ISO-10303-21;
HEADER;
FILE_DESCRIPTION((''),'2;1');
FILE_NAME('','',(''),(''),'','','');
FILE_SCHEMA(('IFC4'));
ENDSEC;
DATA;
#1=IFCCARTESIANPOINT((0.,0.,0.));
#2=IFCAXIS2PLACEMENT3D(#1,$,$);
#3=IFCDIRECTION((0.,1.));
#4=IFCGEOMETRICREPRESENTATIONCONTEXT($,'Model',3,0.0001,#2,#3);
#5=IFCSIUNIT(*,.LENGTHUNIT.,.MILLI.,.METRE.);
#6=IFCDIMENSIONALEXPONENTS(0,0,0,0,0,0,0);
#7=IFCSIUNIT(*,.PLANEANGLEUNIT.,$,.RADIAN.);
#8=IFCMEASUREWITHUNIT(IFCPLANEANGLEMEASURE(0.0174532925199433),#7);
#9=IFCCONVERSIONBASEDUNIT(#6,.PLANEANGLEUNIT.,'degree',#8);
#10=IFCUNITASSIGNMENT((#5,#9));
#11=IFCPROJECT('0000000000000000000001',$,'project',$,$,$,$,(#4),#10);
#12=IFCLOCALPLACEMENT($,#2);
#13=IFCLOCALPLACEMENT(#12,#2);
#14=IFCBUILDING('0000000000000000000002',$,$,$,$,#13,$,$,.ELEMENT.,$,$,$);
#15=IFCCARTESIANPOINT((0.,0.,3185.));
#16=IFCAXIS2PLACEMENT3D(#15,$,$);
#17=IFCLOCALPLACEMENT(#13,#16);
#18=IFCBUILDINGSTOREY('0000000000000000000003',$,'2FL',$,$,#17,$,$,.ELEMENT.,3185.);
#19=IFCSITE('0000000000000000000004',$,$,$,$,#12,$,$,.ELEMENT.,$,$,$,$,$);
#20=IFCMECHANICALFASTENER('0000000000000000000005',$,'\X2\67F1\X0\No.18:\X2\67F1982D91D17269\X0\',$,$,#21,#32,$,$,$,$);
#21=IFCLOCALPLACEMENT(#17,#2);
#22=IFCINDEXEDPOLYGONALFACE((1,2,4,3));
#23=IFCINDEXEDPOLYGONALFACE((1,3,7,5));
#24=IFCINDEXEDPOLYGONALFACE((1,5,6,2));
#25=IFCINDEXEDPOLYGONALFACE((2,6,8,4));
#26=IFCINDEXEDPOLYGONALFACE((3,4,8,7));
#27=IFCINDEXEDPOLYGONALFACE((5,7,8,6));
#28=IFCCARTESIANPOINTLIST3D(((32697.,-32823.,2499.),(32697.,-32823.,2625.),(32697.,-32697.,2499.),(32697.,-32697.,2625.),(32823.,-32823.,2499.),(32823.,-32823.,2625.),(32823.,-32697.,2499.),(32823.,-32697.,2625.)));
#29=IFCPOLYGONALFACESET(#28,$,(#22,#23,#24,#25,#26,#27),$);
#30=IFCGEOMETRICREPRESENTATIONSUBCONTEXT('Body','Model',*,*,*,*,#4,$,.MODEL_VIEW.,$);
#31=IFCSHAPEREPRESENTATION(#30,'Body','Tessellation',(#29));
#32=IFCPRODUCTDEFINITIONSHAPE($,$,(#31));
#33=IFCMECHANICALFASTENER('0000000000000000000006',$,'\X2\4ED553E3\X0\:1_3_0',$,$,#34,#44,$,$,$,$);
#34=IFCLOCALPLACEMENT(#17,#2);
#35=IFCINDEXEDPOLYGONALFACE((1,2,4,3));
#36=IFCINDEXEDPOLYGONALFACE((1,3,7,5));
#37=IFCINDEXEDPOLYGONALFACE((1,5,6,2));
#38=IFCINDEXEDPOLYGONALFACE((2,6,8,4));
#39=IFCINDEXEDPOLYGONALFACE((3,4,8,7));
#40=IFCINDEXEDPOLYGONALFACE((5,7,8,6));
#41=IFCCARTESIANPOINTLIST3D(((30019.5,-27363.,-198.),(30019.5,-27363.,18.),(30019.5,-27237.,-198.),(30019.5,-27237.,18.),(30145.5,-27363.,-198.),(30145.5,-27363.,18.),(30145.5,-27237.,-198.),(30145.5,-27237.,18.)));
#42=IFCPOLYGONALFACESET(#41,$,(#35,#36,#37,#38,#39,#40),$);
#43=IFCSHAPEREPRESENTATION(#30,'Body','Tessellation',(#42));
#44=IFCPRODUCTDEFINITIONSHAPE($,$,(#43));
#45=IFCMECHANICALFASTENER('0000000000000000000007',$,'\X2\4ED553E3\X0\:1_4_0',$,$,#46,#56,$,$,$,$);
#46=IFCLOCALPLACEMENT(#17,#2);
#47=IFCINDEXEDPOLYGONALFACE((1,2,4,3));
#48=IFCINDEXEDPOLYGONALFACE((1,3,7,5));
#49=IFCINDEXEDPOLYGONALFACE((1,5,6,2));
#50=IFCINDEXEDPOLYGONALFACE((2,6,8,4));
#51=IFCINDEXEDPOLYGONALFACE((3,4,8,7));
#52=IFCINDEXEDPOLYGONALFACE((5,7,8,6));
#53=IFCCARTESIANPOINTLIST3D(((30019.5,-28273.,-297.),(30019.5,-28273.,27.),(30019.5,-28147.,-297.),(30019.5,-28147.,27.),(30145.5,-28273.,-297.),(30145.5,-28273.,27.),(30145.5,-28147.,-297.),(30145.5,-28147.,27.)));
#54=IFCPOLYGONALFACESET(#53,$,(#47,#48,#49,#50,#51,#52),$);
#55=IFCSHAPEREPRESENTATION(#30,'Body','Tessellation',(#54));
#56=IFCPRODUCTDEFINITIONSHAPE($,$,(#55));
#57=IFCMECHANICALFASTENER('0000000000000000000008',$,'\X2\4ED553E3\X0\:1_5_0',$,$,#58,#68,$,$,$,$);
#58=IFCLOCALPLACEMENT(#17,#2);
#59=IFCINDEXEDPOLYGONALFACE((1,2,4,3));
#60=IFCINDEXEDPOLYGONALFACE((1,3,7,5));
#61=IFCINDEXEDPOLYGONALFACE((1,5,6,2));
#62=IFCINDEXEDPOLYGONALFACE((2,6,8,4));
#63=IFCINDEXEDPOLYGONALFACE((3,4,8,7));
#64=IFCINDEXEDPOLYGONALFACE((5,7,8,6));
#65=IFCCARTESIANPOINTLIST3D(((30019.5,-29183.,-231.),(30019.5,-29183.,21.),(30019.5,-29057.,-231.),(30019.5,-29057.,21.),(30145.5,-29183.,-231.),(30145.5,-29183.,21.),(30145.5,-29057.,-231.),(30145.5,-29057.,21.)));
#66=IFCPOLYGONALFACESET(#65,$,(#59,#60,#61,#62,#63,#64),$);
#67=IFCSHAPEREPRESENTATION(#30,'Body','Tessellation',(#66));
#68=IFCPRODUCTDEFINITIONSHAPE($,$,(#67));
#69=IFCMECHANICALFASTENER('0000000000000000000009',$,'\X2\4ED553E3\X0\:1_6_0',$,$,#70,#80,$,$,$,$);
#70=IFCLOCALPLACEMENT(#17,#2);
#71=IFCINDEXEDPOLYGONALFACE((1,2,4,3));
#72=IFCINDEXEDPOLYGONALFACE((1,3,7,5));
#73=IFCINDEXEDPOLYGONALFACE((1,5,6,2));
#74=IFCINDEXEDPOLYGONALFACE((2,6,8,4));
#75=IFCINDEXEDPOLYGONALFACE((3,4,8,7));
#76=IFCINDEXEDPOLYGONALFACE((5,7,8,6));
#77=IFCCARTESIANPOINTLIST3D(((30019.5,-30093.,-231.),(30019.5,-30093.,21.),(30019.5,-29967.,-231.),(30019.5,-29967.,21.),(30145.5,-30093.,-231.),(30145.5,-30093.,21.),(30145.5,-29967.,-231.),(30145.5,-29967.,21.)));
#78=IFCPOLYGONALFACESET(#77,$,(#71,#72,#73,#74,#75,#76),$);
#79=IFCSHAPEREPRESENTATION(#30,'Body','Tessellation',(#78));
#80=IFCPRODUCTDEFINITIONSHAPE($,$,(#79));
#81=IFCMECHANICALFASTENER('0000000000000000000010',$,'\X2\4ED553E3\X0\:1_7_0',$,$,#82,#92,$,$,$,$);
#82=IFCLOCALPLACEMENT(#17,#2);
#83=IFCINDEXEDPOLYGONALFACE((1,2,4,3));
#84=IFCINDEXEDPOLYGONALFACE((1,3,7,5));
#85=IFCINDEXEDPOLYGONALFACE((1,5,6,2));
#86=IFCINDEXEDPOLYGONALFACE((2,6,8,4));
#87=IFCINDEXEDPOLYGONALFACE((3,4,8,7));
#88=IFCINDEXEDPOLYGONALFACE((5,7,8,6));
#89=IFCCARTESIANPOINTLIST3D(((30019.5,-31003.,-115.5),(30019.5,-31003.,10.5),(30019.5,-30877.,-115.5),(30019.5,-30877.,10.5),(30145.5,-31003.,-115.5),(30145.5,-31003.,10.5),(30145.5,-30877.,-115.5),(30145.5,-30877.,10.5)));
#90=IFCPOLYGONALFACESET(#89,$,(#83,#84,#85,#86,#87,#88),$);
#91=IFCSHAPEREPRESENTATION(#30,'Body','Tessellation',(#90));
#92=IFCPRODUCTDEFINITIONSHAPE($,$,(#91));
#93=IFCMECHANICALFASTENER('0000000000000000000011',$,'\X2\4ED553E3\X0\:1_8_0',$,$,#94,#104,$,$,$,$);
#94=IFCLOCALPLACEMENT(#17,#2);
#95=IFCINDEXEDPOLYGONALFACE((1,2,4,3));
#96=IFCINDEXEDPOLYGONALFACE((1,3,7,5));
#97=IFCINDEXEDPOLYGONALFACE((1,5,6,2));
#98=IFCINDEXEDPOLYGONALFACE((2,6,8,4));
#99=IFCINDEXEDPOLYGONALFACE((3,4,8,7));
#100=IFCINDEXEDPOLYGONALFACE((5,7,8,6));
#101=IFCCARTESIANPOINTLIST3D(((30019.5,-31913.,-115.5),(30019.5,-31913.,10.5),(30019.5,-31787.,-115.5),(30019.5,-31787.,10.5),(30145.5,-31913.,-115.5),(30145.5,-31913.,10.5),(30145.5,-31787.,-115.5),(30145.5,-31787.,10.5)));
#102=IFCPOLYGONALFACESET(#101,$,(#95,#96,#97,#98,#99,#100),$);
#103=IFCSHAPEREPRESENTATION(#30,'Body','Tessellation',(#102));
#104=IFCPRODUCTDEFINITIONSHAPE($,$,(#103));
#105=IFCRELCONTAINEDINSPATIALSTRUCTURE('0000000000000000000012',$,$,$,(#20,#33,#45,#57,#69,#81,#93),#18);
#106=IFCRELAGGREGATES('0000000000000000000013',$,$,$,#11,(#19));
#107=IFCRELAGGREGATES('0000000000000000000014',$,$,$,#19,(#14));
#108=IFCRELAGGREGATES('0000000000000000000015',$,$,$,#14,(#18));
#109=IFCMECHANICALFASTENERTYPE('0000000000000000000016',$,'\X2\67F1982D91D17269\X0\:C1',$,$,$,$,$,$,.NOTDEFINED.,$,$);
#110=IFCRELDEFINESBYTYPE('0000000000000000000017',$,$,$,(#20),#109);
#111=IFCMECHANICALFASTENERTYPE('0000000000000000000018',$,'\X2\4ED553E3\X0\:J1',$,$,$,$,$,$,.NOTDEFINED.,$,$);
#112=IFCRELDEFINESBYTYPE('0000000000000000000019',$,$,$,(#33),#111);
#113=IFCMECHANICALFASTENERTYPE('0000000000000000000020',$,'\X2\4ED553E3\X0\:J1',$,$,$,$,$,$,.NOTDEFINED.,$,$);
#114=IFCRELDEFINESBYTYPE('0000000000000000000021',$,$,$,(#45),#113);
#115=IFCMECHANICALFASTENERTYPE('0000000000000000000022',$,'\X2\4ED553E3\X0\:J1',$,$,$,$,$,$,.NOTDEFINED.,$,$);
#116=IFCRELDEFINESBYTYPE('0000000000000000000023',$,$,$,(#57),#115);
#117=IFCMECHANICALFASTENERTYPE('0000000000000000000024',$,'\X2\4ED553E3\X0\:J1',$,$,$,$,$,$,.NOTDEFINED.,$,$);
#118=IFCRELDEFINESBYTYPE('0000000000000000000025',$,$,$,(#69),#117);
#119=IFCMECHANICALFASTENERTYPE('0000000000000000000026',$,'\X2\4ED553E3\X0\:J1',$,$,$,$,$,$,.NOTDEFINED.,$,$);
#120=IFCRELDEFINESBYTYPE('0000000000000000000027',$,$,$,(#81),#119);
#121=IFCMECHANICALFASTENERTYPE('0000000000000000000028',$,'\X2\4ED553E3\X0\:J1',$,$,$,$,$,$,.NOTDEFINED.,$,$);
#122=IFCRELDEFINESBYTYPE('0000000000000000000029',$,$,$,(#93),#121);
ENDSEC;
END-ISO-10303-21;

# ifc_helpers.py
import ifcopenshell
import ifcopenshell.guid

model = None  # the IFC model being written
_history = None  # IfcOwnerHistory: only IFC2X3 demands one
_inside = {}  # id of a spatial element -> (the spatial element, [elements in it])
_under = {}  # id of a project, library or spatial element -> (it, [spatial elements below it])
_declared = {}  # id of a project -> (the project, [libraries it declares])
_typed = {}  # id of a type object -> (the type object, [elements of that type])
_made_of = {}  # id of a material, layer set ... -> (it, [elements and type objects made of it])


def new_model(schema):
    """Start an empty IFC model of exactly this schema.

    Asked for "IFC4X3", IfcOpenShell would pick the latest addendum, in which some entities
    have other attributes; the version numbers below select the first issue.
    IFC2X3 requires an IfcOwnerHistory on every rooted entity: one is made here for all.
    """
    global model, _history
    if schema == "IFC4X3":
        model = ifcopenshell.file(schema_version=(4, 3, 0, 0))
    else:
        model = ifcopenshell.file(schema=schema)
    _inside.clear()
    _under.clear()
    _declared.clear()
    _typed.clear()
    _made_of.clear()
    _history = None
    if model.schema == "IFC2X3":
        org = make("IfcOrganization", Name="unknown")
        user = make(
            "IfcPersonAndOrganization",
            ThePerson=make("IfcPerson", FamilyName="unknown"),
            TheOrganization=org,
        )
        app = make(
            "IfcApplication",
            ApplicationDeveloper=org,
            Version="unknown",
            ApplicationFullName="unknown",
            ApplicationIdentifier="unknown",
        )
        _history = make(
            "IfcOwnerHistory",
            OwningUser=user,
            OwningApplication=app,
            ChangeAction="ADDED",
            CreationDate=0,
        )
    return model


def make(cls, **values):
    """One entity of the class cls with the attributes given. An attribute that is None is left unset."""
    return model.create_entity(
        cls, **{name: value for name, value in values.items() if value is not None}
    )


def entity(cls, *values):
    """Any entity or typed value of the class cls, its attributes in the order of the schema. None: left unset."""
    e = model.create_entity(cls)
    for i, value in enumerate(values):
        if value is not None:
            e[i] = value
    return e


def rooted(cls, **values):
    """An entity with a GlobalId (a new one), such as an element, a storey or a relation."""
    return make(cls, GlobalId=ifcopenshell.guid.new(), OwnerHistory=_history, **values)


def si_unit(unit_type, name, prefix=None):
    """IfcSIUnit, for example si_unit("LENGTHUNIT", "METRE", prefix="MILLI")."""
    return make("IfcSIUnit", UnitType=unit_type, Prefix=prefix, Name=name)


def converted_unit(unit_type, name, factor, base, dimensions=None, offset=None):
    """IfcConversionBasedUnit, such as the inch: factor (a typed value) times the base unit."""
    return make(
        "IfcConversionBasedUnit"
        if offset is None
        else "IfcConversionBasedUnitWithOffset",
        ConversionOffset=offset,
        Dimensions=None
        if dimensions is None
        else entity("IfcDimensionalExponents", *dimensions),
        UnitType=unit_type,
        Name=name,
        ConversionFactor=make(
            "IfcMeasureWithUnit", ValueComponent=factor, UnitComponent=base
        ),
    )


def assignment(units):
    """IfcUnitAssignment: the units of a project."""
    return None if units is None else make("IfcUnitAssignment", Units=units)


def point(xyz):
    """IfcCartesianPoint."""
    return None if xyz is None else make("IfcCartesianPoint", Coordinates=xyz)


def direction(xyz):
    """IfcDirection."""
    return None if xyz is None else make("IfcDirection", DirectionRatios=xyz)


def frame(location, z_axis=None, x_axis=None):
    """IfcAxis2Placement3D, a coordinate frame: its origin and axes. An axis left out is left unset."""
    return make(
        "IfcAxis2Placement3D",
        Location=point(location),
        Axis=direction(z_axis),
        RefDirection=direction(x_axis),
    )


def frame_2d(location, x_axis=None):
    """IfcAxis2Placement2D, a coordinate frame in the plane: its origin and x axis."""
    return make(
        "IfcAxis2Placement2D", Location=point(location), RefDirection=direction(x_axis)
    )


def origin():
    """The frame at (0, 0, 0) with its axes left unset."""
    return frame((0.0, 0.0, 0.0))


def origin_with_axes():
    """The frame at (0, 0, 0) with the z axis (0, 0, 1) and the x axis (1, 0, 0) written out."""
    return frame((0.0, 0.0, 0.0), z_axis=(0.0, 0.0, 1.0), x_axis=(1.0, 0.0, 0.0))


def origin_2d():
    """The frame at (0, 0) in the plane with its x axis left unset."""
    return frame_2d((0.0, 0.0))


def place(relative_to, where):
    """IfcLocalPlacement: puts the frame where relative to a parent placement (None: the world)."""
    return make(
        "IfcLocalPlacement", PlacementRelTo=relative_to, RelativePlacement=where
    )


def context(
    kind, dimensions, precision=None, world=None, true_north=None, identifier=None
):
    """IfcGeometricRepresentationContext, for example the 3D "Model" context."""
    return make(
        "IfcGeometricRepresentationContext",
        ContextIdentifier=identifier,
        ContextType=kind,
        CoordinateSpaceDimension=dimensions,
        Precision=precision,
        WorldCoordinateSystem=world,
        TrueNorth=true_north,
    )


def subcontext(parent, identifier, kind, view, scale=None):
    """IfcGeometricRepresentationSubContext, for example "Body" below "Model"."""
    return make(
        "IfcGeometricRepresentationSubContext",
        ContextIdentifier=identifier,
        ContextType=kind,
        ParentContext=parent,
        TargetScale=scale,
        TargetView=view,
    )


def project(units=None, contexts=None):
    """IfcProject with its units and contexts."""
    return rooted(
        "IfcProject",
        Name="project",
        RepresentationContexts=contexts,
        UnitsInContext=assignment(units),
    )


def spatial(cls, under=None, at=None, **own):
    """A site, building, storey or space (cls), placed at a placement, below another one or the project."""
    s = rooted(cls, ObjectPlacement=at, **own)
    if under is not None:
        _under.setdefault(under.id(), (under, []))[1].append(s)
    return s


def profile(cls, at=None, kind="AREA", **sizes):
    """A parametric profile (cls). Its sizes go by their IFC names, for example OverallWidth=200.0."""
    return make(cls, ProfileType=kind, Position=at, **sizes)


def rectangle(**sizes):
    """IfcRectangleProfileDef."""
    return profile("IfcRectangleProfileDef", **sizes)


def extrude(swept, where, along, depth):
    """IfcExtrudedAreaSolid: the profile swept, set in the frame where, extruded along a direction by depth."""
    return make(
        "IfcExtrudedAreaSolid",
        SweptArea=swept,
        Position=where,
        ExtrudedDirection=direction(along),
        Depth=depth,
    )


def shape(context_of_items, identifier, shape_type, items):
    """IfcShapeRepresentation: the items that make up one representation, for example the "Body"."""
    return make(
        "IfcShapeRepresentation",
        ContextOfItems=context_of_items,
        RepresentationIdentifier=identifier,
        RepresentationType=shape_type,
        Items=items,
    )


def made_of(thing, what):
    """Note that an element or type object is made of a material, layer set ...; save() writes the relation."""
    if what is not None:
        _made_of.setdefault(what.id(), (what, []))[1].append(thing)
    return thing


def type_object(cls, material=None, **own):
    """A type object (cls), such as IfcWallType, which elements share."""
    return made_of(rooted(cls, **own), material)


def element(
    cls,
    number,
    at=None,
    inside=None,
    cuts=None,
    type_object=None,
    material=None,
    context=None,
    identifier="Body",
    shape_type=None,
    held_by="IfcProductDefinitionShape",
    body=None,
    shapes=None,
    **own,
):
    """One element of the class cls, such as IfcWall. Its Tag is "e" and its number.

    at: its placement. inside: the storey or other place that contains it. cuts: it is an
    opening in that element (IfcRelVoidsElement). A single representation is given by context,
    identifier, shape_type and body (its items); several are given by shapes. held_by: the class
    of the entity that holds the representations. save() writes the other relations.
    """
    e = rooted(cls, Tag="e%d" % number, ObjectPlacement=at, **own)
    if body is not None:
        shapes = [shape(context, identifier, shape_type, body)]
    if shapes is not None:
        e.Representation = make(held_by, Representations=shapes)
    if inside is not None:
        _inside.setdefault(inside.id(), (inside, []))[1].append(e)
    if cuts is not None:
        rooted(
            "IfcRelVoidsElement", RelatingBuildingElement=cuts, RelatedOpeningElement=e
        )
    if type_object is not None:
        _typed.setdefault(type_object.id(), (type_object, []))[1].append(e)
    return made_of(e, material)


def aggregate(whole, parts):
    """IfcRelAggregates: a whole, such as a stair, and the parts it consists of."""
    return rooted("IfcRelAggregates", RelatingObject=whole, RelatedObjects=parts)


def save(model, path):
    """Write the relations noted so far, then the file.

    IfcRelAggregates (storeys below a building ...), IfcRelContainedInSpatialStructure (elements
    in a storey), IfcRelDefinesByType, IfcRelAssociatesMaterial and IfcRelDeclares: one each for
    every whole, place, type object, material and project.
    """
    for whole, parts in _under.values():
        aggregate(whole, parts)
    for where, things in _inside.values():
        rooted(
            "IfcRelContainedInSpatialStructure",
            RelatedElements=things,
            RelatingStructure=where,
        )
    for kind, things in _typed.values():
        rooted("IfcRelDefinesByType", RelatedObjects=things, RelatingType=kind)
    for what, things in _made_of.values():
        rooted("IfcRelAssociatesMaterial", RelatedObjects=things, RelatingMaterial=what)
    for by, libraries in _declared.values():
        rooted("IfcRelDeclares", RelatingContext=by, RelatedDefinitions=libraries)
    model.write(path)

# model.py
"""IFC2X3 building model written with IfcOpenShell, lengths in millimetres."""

from ifc_helpers import new_model, entity, si_unit, converted_unit, direction, frame, origin, origin_with_axes, origin_2d, place, context, subcontext, project, spatial, rectangle, extrude, type_object, element, save


model = new_model("IFC2X3")

# Units and contexts
model_context = context("Model", 3, precision=0.0001, world=origin(), true_north=direction((0.0, 1.0)))
body_context = subcontext(model_context, "Body", "Model", "MODEL_VIEW")
ifc_project = project(units=[si_unit("LENGTHUNIT", "METRE", prefix="MILLI"), converted_unit("PLANEANGLEUNIT", "degree", entity("IfcPlaneAngleMeasure", 0.0174532925199433), si_unit("PLANEANGLEUNIT", "RADIAN"), dimensions=[0, 0, 0, 0, 0, 0, 0])], contexts=[model_context])

# Site, building, storey
site_placement = place(None, origin())
site = spatial("IfcSite", under=ifc_project, at=site_placement, CompositionType="ELEMENT")
building_placement = place(site_placement, origin())
building = spatial("IfcBuilding", under=site, at=building_placement, CompositionType="ELEMENT")
storey_placement = place(building_placement, frame((0.0, 0.0, 3185.0)))
storey = spatial("IfcBuildingStorey", under=building, at=storey_placement, Name="2FL", CompositionType="ELEMENT", Elevation=3185.0)

# Mechanical fasteners
mechanical_fastener_type_1 = type_object("IfcMechanicalFastenerType", Name="柱頭金物:C1")
mechanical_fastener_1_placement = place(storey_placement, frame((32760.0, -32760.0, 2499.0)))
element("IfcMechanicalFastener", 1, at=mechanical_fastener_1_placement, inside=storey, type_object=mechanical_fastener_type_1, Name="柱No.18:柱頭金物", context=body_context, shape_type="SweptSolid", body=[
    extrude(rectangle(XDim=126.0, YDim=126.0, at=origin_2d()), origin_with_axes(), (0.0, 0.0, 1.0), 126.0),
])
mechanical_fastener_type_2 = type_object("IfcMechanicalFastenerType", Name="仕口:J1")
mechanical_fastener_2_placement = place(storey_placement, frame((30082.5, -27300.0, -198.0)))
element("IfcMechanicalFastener", 2, at=mechanical_fastener_2_placement, inside=storey, type_object=mechanical_fastener_type_2, Name="仕口:1_3_0", context=body_context, shape_type="SweptSolid", body=[
    extrude(rectangle(XDim=126.0, YDim=126.0, at=origin_2d()), origin_with_axes(), (0.0, 0.0, 1.0), 216.0),
])
mechanical_fastener_type_3 = type_object("IfcMechanicalFastenerType", Name="仕口:J1")
mechanical_fastener_3_placement = place(storey_placement, frame((30082.5, -28210.0, -297.0)))
element("IfcMechanicalFastener", 3, at=mechanical_fastener_3_placement, inside=storey, type_object=mechanical_fastener_type_3, Name="仕口:1_4_0", context=body_context, shape_type="SweptSolid", body=[
    extrude(rectangle(XDim=126.0, YDim=126.0, at=origin_2d()), origin_with_axes(), (0.0, 0.0, 1.0), 324.0),
])
mechanical_fastener_type_4 = type_object("IfcMechanicalFastenerType", Name="仕口:J1")
mechanical_fastener_4_placement = place(storey_placement, frame((30082.5, -29120.0, -231.0)))
element("IfcMechanicalFastener", 4, at=mechanical_fastener_4_placement, inside=storey, type_object=mechanical_fastener_type_4, Name="仕口:1_5_0", context=body_context, shape_type="SweptSolid", body=[
    extrude(rectangle(XDim=126.0, YDim=126.0, at=origin_2d()), origin_with_axes(), (0.0, 0.0, 1.0), 252.0),
])
mechanical_fastener_type_5 = type_object("IfcMechanicalFastenerType", Name="仕口:J1")
mechanical_fastener_5_placement = place(storey_placement, frame((30082.5, -30030.0, -231.0)))
element("IfcMechanicalFastener", 5, at=mechanical_fastener_5_placement, inside=storey, type_object=mechanical_fastener_type_5, Name="仕口:1_6_0", context=body_context, shape_type="SweptSolid", body=[
    extrude(rectangle(XDim=126.0, YDim=126.0, at=origin_2d()), origin_with_axes(), (0.0, 0.0, 1.0), 252.0),
])
mechanical_fastener_type_6 = type_object("IfcMechanicalFastenerType", Name="仕口:J1")
mechanical_fastener_6_placement = place(storey_placement, frame((30082.5, -30940.0, -115.5)))
element("IfcMechanicalFastener", 6, at=mechanical_fastener_6_placement, inside=storey, type_object=mechanical_fastener_type_6, Name="仕口:1_7_0", context=body_context, shape_type="SweptSolid", body=[
    extrude(rectangle(XDim=126.0, YDim=126.0, at=origin_2d()), origin_with_axes(), (0.0, 0.0, 1.0), 126.0),
])
mechanical_fastener_type_7 = type_object("IfcMechanicalFastenerType", Name="仕口:J1")
mechanical_fastener_7_placement = place(storey_placement, frame((30082.5, -31850.0, -115.5)))
element("IfcMechanicalFastener", 7, at=mechanical_fastener_7_placement, inside=storey, type_object=mechanical_fastener_type_7, Name="仕口:1_8_0", context=body_context, shape_type="SweptSolid", body=[
    extrude(rectangle(XDim=126.0, YDim=126.0, at=origin_2d()), origin_with_axes(), (0.0, 0.0, 1.0), 126.0),
])

save(model, "model.ifc")
